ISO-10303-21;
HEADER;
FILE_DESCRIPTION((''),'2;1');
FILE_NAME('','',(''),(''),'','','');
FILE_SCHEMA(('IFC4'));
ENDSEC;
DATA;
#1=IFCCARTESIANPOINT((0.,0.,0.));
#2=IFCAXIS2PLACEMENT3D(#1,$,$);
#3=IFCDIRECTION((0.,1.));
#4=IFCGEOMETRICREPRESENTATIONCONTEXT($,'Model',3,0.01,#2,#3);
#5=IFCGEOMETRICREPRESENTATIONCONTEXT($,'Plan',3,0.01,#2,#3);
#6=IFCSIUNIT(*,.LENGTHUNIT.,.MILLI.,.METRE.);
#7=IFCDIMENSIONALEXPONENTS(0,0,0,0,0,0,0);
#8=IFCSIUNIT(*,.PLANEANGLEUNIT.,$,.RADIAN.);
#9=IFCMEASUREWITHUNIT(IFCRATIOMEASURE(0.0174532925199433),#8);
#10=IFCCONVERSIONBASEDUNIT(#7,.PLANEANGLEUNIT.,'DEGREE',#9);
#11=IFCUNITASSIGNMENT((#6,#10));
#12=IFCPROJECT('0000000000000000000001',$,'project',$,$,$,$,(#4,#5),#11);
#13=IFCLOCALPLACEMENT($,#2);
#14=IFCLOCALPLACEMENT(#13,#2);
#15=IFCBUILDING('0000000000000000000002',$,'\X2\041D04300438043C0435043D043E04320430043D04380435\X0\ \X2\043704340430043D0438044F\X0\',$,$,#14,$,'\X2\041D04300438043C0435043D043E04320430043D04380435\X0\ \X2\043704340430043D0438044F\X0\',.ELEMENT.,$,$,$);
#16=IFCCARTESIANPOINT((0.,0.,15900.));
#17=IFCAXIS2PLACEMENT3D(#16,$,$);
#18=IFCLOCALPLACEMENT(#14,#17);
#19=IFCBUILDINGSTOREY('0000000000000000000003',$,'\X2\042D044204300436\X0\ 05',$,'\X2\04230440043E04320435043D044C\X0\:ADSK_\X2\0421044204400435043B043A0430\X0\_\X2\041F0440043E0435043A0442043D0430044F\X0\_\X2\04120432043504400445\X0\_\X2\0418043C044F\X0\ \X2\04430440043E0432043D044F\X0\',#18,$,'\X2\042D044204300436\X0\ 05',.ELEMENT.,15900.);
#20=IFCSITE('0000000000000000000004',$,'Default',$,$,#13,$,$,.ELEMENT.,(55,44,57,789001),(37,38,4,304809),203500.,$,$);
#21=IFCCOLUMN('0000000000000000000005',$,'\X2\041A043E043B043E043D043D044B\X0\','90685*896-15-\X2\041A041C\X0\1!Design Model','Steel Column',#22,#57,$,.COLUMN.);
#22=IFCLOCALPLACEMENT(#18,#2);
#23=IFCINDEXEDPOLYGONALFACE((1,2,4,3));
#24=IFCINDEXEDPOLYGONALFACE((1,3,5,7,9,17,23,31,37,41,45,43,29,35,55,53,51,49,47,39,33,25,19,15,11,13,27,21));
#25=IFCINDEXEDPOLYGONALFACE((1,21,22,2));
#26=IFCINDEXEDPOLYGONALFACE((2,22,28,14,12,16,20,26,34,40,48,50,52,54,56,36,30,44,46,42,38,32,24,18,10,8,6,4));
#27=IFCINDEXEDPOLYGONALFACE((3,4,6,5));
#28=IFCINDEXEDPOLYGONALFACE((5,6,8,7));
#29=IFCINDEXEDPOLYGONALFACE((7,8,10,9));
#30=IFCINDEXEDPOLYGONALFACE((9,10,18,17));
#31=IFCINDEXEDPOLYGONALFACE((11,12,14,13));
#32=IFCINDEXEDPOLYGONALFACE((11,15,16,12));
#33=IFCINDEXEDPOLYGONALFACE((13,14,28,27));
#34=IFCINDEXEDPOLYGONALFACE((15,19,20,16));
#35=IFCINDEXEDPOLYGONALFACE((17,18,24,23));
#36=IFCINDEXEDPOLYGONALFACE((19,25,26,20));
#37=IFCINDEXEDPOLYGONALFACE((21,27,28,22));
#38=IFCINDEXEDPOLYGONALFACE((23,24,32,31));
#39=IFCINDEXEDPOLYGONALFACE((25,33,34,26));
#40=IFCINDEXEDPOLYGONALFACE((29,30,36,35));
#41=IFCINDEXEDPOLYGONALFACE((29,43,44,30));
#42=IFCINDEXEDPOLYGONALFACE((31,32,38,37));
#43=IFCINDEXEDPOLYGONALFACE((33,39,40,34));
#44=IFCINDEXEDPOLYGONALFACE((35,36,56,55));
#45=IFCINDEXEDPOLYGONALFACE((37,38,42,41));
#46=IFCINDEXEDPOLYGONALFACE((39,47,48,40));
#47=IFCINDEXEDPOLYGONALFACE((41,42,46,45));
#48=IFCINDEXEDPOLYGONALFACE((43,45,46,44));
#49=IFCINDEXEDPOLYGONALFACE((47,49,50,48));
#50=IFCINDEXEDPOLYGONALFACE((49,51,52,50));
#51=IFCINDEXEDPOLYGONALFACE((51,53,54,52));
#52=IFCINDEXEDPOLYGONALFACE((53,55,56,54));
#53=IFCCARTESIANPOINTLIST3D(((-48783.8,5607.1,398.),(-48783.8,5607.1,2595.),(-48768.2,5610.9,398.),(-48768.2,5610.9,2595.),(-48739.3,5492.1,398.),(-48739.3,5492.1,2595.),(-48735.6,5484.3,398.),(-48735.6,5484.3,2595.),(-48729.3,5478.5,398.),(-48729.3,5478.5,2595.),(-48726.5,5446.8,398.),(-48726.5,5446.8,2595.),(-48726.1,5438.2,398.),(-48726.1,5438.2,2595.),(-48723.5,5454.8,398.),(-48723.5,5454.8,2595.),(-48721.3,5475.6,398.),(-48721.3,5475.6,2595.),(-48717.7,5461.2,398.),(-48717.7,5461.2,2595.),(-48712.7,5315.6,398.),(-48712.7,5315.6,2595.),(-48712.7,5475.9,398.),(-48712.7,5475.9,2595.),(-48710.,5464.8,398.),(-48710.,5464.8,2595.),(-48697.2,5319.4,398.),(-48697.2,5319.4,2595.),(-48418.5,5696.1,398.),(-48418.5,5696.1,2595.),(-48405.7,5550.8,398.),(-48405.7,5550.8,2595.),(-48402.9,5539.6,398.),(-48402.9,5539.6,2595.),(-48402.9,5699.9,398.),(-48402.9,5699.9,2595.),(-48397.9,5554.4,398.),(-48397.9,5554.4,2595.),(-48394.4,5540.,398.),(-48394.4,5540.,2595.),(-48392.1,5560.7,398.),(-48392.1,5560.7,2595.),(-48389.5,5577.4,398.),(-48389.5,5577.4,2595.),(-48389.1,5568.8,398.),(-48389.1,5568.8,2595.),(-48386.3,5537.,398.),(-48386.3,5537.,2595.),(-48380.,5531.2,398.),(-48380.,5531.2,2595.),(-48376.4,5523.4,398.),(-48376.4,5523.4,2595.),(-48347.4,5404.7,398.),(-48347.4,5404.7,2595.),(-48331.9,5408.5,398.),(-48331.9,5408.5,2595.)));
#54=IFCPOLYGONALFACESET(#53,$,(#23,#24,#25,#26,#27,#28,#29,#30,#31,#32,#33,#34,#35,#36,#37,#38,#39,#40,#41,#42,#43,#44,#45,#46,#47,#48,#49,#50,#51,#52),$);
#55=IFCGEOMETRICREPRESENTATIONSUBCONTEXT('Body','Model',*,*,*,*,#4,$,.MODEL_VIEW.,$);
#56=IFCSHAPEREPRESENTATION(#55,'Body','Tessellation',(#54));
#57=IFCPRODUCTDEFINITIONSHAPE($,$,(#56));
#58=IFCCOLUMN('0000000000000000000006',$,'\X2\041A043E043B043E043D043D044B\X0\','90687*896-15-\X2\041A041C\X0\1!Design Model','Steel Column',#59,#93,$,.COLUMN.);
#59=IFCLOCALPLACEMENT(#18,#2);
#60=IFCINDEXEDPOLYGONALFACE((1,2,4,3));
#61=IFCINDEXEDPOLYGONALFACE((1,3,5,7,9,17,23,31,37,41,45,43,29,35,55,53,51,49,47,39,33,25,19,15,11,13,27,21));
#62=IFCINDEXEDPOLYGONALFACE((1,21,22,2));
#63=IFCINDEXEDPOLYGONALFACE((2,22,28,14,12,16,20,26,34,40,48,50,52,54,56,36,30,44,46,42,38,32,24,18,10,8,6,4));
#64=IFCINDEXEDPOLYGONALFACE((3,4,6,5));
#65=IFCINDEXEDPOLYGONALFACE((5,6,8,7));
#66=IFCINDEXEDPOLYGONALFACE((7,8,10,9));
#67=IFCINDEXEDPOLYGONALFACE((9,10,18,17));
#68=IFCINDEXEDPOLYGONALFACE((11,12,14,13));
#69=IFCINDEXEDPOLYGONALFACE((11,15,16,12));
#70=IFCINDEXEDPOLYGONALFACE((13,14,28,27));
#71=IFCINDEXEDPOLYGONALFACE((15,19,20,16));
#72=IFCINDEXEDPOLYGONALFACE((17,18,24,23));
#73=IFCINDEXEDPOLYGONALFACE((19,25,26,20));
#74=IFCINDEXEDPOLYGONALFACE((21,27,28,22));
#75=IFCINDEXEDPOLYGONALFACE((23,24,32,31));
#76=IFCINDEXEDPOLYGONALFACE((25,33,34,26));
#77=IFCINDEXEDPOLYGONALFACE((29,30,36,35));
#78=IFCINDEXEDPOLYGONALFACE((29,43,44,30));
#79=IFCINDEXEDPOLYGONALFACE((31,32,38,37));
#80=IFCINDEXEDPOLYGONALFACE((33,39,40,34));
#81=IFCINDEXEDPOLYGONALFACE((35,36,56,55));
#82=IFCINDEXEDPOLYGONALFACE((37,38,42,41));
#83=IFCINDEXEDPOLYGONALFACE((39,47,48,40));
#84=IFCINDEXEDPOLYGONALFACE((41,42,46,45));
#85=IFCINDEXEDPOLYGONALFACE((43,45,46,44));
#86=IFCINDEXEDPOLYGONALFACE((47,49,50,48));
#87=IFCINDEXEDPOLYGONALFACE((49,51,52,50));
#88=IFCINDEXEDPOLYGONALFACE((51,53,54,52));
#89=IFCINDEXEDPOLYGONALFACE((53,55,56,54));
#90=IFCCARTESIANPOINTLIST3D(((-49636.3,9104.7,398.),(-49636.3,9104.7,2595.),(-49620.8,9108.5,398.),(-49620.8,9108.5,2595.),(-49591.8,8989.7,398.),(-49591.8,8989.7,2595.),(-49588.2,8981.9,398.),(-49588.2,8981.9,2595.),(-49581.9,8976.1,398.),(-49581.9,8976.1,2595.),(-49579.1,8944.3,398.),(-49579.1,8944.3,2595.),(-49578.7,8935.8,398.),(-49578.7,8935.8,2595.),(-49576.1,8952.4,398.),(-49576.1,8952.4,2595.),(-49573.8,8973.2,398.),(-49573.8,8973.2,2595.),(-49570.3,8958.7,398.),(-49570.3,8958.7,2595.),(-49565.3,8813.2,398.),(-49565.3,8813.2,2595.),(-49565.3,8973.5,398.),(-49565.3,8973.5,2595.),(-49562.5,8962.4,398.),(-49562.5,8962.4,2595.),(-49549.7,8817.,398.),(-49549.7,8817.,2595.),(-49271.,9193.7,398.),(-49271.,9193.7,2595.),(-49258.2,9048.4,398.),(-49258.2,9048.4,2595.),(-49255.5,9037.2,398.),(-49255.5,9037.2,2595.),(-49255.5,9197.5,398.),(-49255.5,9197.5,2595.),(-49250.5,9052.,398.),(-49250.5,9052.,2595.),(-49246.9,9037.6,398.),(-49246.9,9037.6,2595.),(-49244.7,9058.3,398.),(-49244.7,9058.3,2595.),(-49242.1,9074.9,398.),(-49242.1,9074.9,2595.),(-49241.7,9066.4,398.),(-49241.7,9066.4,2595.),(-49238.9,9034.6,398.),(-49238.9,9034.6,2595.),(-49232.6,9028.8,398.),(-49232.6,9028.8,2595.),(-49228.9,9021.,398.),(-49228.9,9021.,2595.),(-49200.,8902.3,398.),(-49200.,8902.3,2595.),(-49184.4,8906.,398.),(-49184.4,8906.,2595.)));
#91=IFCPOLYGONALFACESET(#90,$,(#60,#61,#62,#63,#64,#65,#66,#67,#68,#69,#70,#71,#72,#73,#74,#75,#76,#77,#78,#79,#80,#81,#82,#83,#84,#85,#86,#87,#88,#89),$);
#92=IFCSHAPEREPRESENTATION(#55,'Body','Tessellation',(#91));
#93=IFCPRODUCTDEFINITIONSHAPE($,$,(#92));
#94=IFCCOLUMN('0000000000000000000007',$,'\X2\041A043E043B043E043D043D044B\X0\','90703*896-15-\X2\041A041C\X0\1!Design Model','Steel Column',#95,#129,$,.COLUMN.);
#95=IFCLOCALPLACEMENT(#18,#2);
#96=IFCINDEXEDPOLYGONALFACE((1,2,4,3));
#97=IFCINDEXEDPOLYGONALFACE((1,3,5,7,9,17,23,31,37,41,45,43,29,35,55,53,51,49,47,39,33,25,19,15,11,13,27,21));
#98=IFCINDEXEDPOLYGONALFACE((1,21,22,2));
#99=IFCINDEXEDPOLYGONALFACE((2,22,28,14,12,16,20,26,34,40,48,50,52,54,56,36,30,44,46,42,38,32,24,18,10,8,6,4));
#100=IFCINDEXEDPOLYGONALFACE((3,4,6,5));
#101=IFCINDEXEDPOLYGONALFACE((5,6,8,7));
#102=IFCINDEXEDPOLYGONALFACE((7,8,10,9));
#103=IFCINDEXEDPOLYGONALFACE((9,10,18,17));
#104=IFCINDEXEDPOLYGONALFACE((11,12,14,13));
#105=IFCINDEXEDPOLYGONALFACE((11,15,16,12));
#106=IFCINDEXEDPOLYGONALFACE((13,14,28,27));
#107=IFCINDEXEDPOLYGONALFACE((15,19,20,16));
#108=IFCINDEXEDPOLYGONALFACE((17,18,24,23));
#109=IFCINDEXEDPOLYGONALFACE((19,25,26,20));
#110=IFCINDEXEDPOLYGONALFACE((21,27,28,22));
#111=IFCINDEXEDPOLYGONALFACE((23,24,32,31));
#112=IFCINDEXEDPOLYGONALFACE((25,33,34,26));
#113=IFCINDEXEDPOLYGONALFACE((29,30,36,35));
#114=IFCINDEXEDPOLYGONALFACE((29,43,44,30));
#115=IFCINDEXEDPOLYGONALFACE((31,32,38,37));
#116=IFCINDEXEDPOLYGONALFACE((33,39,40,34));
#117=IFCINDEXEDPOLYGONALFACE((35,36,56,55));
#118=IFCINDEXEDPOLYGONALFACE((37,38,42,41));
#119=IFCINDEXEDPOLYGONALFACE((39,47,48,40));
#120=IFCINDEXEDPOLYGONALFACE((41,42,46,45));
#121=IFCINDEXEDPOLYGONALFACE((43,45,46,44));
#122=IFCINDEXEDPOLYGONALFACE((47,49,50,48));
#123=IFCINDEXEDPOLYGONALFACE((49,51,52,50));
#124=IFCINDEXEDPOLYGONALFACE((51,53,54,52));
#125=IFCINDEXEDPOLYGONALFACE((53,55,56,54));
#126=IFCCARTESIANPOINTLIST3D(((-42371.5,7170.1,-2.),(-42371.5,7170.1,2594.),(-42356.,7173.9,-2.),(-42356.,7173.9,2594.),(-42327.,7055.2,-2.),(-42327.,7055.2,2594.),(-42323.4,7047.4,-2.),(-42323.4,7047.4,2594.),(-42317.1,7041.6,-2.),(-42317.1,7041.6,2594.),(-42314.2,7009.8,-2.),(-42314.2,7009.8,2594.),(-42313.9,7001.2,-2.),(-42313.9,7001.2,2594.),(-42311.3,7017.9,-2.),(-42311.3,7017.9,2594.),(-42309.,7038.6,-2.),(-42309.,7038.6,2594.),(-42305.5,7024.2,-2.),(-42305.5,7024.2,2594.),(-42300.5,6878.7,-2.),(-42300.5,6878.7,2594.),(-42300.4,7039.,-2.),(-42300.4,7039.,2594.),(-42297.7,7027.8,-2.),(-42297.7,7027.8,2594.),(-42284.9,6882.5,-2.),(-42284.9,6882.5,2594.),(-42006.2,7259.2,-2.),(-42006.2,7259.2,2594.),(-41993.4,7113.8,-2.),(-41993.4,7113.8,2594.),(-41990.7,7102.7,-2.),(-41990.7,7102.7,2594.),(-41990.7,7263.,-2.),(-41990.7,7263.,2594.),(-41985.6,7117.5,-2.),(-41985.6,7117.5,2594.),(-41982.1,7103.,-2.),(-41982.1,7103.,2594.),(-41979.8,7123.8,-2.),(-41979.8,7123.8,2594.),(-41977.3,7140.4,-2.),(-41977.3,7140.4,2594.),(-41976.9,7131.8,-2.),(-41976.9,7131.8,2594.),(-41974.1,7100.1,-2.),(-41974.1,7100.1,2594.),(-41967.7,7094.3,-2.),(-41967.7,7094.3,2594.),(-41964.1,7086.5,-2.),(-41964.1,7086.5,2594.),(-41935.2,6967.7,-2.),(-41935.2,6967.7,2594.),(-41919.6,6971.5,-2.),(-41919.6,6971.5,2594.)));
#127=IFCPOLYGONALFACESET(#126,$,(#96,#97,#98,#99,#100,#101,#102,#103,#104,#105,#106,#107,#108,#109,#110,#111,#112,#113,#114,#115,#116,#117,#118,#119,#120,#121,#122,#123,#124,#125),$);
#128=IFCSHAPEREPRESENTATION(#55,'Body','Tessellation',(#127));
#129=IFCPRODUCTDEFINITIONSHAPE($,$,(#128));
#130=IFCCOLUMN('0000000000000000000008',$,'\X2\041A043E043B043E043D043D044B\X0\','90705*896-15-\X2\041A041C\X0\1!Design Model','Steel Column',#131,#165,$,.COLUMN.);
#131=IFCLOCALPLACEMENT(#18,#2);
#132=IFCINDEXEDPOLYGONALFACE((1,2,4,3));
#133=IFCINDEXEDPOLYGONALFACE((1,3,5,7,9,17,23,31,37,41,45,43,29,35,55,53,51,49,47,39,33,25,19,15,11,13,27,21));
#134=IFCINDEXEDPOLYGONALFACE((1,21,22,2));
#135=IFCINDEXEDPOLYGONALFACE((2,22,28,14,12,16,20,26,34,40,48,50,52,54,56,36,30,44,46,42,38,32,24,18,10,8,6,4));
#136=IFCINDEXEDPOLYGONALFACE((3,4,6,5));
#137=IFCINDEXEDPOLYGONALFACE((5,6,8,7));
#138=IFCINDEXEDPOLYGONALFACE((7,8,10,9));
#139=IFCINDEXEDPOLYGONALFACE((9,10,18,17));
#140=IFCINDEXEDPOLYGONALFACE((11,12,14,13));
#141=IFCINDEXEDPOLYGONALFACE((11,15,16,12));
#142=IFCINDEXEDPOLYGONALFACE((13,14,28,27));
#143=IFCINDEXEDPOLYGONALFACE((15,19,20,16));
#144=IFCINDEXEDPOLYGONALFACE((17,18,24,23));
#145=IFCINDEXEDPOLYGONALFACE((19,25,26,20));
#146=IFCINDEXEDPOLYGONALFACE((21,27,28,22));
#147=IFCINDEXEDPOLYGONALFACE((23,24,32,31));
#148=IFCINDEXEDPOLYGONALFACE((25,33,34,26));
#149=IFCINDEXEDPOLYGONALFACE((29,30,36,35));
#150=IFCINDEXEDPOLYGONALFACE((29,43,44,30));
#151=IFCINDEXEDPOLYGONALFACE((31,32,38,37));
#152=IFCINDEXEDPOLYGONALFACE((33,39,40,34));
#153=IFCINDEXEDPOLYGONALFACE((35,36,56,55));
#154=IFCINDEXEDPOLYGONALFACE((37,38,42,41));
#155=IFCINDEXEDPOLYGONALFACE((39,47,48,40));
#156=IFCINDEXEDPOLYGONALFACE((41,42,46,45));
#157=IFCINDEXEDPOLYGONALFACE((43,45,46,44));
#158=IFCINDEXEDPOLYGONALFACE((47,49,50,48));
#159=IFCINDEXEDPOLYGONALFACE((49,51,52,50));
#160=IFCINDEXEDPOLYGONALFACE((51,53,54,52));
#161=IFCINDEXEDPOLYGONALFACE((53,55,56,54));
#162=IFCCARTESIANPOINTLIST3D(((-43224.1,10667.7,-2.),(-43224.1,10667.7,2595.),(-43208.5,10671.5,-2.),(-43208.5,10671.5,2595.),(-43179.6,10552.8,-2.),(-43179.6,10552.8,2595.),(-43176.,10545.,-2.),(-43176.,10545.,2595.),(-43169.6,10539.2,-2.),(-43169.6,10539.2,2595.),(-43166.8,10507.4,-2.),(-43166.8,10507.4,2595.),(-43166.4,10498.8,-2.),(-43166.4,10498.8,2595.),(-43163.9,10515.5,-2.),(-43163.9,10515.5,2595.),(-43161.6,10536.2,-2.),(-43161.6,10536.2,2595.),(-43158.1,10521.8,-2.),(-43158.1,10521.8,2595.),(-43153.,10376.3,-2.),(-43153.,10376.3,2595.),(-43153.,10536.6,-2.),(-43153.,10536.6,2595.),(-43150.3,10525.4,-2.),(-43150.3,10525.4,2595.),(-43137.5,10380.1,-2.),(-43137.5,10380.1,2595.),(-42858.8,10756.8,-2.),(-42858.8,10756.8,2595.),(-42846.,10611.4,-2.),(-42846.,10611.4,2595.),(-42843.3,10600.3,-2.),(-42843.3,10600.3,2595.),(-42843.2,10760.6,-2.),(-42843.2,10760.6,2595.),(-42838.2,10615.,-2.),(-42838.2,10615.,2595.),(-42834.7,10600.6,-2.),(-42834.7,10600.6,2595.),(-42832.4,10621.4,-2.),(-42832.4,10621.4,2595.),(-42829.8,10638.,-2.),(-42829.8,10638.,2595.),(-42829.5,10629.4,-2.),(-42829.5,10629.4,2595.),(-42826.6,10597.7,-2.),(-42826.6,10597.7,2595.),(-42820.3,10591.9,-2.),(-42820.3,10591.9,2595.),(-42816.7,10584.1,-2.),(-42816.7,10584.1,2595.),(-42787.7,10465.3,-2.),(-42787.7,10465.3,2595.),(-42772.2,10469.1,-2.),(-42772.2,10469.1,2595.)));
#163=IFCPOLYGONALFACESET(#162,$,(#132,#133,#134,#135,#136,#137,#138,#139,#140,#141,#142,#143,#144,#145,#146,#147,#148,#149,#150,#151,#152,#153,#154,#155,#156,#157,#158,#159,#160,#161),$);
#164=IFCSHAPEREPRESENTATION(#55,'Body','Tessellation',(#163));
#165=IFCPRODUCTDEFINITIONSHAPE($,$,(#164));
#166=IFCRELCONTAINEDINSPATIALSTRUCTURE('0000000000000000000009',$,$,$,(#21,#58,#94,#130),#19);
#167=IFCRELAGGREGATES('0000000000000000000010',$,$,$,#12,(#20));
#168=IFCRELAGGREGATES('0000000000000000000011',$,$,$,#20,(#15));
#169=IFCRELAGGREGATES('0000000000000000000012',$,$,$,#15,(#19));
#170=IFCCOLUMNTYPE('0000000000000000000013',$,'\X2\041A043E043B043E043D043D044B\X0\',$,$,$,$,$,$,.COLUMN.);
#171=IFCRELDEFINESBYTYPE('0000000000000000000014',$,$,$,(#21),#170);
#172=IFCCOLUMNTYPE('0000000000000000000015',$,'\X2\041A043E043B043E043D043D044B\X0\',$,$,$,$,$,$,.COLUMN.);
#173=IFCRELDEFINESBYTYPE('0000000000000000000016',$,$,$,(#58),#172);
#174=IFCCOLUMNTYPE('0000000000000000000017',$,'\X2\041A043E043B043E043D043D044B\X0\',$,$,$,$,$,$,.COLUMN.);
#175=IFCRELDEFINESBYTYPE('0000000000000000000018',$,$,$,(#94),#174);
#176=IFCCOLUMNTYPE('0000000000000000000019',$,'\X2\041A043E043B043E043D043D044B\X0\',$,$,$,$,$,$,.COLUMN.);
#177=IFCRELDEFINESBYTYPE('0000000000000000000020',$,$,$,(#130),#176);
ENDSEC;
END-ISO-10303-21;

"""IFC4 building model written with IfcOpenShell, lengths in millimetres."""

from ifc_helpers import new_model, entity, si_unit, converted_unit, direction, frame, origin, place, context, subcontext, project, spatial, indexed_curve, outline, extrude, type_object, element, save


model = new_model("IFC4")

# Units and contexts
model_context = context("Model", 3, precision=0.01, world=origin(), true_north=direction((0.0, 1.0)))
plan_context = context("Plan", 3, precision=0.01, world=origin(), true_north=direction((0.0, 1.0)))
body_context = subcontext(model_context, "Body", "Model", "MODEL_VIEW")
ifc_project = project(units=[si_unit("LENGTHUNIT", "METRE", prefix="MILLI"), converted_unit("PLANEANGLEUNIT", "DEGREE", entity("IfcRatioMeasure", 0.0174532925199433), si_unit("PLANEANGLEUNIT", "RADIAN"), dimensions=[0, 0, 0, 0, 0, 0, 0])], contexts=[model_context, plan_context])

# Site, building, storey
site_placement = place(None, origin())
site = spatial("IfcSite", under=ifc_project, at=site_placement, Name="Default", CompositionType="ELEMENT", RefLatitude=(55, 44, 57, 789001), RefLongitude=(37, 38, 4, 304809), RefElevation=203500.0)
building_placement = place(site_placement, origin())
building = spatial("IfcBuilding", under=site, at=building_placement, Name="Наименование здания", LongName="Наименование здания", CompositionType="ELEMENT")
storey_placement = place(building_placement, frame((0.0, 0.0, 15900.0)))
storey = spatial("IfcBuildingStorey", under=building, at=storey_placement, Name="Этаж 05", ObjectType="Уровень:ADSK_Стрелка_Проектная_Вверх_Имя уровня", LongName="Этаж 05", CompositionType="ELEMENT", Elevation=15900.0)

# Columns
placement = place(storey_placement, origin())
column_type_1 = type_object("IfcColumnType", Name="Колонны", PredefinedType="COLUMN")
element("IfcColumn", 1, at=placement, inside=storey, type_object=column_type_1, Name="Колонны", Description="90685*896-15-КМ1!Design Model", ObjectType="Steel Column", PredefinedType="COLUMN", context=body_context, shape_type="SweptSolid", body=[
    extrude(outline(indexed_curve([(-196.0, -150.0), (-180.0, -150.0), (-180.0, -27.7), (-178.3, -19.3), (-173.6, -12.2), (-166.4, -7.4), (-158.0, -5.7), (158.0, -5.8), (166.4, -7.4), (173.6, -12.2), (178.3, -19.3), (180.0, -27.8), (180.0, -150.0), (196.0, -150.0), (196.0, 150.0), (180.0, 150.0), (180.0, 27.7), (178.3, 19.3), (173.6, 12.2), (166.4, 7.4), (158.0, 5.7), (-158.0, 5.8), (-166.4, 7.4), (-173.6, 12.2), (-178.3, 19.3), (-180.0, 27.8), (-180.0, 150.0), (-196.0, 150.0), (-196.0, -150.0)], self_intersect=False)), frame((-48557.8, 5507.8, 398.0), z_axis=(0.0, 0.0, 1.0), x_axis=(-0.971552, -0.236826, 0.0)), (0.0, 0.0, 1.0), 2197.0),
])
column_type_2 = type_object("IfcColumnType", Name="Колонны", PredefinedType="COLUMN")
element("IfcColumn", 2, at=placement, inside=storey, type_object=column_type_2, Name="Колонны", Description="90687*896-15-КМ1!Design Model", ObjectType="Steel Column", PredefinedType="COLUMN", context=body_context, shape_type="SweptSolid", body=[
    extrude(outline(indexed_curve([(-196.0, -150.0), (-180.0, -150.0), (-180.0, -27.8), (-178.3, -19.3), (-173.6, -12.2), (-166.4, -7.4), (-158.0, -5.8), (158.0, -5.7), (166.4, -7.4), (173.6, -12.2), (178.3, -19.3), (180.0, -27.7), (180.0, -150.0), (196.0, -150.0), (196.0, 150.0), (180.0, 150.0), (180.0, 27.8), (178.3, 19.3), (173.6, 12.2), (166.4, 7.4), (158.0, 5.8), (-158.0, 5.7), (-166.4, 7.4), (-173.6, 12.2), (-178.3, 19.3), (-180.0, 27.7), (-180.0, 150.0), (-196.0, 150.0), (-196.0, -150.0)], self_intersect=False)), frame((-49410.4, 9005.4, 398.0), z_axis=(0.0, 0.0, 1.0), x_axis=(-0.971552, -0.236826, 0.0)), (0.0, 0.0, 1.0), 2197.0),
])
column_type_3 = type_object("IfcColumnType", Name="Колонны", PredefinedType="COLUMN")
element("IfcColumn", 3, at=placement, inside=storey, type_object=column_type_3, Name="Колонны", Description="90703*896-15-КМ1!Design Model", ObjectType="Steel Column", PredefinedType="COLUMN", context=body_context, shape_type="SweptSolid", body=[
    extrude(outline(indexed_curve([(-196.0, -150.0), (-180.0, -150.0), (-180.0, -27.8), (-178.3, -19.3), (-173.6, -12.2), (-166.4, -7.4), (-158.0, -5.8), (158.0, -5.8), (166.4, -7.4), (173.6, -12.2), (178.3, -19.3), (180.0, -27.7), (180.0, -150.0), (196.0, -150.0), (196.0, 150.0), (180.0, 150.0), (180.0, 27.8), (178.3, 19.3), (173.6, 12.2), (166.4, 7.4), (158.0, 5.8), (-158.0, 5.7), (-166.4, 7.4), (-173.6, 12.2), (-178.3, 19.3), (-180.0, 27.7), (-180.0, 150.0), (-196.0, 150.0), (-196.0, -150.0)], self_intersect=False)), frame((-42145.6, 7070.8, -2.0), z_axis=(0.0, 0.0, 1.0), x_axis=(-0.971552, -0.236826, 0.0)), (0.0, 0.0, 1.0), 2596.0),
])
column_type_4 = type_object("IfcColumnType", Name="Колонны", PredefinedType="COLUMN")
element("IfcColumn", 4, at=placement, inside=storey, type_object=column_type_4, Name="Колонны", Description="90705*896-15-КМ1!Design Model", ObjectType="Steel Column", PredefinedType="COLUMN", context=body_context, shape_type="SweptSolid", body=[
    extrude(outline(indexed_curve([(-196.0, -150.0), (-180.0, -150.0), (-180.0, -27.8), (-178.3, -19.3), (-173.6, -12.2), (-166.4, -7.4), (-158.0, -5.8), (158.0, -5.8), (166.4, -7.4), (173.6, -12.2), (178.3, -19.3), (180.0, -27.8), (180.0, -150.0), (196.0, -150.0), (196.0, 150.0), (180.0, 150.0), (180.0, 27.7), (178.3, 19.3), (173.6, 12.2), (166.4, 7.4), (158.0, 5.7), (-158.0, 5.7), (-166.4, 7.4), (-173.6, 12.2), (-178.3, 19.3), (-180.0, 27.7), (-180.0, 150.0), (-196.0, 150.0), (-196.0, -150.0)], self_intersect=False)), frame((-42998.1, 10568.4, -2.0), z_axis=(0.0, 0.0, 1.0), x_axis=(-0.971552, -0.236826, 0.0)), (0.0, 0.0, 1.0), 2597.0),
])

save(model, "model.ifc")
